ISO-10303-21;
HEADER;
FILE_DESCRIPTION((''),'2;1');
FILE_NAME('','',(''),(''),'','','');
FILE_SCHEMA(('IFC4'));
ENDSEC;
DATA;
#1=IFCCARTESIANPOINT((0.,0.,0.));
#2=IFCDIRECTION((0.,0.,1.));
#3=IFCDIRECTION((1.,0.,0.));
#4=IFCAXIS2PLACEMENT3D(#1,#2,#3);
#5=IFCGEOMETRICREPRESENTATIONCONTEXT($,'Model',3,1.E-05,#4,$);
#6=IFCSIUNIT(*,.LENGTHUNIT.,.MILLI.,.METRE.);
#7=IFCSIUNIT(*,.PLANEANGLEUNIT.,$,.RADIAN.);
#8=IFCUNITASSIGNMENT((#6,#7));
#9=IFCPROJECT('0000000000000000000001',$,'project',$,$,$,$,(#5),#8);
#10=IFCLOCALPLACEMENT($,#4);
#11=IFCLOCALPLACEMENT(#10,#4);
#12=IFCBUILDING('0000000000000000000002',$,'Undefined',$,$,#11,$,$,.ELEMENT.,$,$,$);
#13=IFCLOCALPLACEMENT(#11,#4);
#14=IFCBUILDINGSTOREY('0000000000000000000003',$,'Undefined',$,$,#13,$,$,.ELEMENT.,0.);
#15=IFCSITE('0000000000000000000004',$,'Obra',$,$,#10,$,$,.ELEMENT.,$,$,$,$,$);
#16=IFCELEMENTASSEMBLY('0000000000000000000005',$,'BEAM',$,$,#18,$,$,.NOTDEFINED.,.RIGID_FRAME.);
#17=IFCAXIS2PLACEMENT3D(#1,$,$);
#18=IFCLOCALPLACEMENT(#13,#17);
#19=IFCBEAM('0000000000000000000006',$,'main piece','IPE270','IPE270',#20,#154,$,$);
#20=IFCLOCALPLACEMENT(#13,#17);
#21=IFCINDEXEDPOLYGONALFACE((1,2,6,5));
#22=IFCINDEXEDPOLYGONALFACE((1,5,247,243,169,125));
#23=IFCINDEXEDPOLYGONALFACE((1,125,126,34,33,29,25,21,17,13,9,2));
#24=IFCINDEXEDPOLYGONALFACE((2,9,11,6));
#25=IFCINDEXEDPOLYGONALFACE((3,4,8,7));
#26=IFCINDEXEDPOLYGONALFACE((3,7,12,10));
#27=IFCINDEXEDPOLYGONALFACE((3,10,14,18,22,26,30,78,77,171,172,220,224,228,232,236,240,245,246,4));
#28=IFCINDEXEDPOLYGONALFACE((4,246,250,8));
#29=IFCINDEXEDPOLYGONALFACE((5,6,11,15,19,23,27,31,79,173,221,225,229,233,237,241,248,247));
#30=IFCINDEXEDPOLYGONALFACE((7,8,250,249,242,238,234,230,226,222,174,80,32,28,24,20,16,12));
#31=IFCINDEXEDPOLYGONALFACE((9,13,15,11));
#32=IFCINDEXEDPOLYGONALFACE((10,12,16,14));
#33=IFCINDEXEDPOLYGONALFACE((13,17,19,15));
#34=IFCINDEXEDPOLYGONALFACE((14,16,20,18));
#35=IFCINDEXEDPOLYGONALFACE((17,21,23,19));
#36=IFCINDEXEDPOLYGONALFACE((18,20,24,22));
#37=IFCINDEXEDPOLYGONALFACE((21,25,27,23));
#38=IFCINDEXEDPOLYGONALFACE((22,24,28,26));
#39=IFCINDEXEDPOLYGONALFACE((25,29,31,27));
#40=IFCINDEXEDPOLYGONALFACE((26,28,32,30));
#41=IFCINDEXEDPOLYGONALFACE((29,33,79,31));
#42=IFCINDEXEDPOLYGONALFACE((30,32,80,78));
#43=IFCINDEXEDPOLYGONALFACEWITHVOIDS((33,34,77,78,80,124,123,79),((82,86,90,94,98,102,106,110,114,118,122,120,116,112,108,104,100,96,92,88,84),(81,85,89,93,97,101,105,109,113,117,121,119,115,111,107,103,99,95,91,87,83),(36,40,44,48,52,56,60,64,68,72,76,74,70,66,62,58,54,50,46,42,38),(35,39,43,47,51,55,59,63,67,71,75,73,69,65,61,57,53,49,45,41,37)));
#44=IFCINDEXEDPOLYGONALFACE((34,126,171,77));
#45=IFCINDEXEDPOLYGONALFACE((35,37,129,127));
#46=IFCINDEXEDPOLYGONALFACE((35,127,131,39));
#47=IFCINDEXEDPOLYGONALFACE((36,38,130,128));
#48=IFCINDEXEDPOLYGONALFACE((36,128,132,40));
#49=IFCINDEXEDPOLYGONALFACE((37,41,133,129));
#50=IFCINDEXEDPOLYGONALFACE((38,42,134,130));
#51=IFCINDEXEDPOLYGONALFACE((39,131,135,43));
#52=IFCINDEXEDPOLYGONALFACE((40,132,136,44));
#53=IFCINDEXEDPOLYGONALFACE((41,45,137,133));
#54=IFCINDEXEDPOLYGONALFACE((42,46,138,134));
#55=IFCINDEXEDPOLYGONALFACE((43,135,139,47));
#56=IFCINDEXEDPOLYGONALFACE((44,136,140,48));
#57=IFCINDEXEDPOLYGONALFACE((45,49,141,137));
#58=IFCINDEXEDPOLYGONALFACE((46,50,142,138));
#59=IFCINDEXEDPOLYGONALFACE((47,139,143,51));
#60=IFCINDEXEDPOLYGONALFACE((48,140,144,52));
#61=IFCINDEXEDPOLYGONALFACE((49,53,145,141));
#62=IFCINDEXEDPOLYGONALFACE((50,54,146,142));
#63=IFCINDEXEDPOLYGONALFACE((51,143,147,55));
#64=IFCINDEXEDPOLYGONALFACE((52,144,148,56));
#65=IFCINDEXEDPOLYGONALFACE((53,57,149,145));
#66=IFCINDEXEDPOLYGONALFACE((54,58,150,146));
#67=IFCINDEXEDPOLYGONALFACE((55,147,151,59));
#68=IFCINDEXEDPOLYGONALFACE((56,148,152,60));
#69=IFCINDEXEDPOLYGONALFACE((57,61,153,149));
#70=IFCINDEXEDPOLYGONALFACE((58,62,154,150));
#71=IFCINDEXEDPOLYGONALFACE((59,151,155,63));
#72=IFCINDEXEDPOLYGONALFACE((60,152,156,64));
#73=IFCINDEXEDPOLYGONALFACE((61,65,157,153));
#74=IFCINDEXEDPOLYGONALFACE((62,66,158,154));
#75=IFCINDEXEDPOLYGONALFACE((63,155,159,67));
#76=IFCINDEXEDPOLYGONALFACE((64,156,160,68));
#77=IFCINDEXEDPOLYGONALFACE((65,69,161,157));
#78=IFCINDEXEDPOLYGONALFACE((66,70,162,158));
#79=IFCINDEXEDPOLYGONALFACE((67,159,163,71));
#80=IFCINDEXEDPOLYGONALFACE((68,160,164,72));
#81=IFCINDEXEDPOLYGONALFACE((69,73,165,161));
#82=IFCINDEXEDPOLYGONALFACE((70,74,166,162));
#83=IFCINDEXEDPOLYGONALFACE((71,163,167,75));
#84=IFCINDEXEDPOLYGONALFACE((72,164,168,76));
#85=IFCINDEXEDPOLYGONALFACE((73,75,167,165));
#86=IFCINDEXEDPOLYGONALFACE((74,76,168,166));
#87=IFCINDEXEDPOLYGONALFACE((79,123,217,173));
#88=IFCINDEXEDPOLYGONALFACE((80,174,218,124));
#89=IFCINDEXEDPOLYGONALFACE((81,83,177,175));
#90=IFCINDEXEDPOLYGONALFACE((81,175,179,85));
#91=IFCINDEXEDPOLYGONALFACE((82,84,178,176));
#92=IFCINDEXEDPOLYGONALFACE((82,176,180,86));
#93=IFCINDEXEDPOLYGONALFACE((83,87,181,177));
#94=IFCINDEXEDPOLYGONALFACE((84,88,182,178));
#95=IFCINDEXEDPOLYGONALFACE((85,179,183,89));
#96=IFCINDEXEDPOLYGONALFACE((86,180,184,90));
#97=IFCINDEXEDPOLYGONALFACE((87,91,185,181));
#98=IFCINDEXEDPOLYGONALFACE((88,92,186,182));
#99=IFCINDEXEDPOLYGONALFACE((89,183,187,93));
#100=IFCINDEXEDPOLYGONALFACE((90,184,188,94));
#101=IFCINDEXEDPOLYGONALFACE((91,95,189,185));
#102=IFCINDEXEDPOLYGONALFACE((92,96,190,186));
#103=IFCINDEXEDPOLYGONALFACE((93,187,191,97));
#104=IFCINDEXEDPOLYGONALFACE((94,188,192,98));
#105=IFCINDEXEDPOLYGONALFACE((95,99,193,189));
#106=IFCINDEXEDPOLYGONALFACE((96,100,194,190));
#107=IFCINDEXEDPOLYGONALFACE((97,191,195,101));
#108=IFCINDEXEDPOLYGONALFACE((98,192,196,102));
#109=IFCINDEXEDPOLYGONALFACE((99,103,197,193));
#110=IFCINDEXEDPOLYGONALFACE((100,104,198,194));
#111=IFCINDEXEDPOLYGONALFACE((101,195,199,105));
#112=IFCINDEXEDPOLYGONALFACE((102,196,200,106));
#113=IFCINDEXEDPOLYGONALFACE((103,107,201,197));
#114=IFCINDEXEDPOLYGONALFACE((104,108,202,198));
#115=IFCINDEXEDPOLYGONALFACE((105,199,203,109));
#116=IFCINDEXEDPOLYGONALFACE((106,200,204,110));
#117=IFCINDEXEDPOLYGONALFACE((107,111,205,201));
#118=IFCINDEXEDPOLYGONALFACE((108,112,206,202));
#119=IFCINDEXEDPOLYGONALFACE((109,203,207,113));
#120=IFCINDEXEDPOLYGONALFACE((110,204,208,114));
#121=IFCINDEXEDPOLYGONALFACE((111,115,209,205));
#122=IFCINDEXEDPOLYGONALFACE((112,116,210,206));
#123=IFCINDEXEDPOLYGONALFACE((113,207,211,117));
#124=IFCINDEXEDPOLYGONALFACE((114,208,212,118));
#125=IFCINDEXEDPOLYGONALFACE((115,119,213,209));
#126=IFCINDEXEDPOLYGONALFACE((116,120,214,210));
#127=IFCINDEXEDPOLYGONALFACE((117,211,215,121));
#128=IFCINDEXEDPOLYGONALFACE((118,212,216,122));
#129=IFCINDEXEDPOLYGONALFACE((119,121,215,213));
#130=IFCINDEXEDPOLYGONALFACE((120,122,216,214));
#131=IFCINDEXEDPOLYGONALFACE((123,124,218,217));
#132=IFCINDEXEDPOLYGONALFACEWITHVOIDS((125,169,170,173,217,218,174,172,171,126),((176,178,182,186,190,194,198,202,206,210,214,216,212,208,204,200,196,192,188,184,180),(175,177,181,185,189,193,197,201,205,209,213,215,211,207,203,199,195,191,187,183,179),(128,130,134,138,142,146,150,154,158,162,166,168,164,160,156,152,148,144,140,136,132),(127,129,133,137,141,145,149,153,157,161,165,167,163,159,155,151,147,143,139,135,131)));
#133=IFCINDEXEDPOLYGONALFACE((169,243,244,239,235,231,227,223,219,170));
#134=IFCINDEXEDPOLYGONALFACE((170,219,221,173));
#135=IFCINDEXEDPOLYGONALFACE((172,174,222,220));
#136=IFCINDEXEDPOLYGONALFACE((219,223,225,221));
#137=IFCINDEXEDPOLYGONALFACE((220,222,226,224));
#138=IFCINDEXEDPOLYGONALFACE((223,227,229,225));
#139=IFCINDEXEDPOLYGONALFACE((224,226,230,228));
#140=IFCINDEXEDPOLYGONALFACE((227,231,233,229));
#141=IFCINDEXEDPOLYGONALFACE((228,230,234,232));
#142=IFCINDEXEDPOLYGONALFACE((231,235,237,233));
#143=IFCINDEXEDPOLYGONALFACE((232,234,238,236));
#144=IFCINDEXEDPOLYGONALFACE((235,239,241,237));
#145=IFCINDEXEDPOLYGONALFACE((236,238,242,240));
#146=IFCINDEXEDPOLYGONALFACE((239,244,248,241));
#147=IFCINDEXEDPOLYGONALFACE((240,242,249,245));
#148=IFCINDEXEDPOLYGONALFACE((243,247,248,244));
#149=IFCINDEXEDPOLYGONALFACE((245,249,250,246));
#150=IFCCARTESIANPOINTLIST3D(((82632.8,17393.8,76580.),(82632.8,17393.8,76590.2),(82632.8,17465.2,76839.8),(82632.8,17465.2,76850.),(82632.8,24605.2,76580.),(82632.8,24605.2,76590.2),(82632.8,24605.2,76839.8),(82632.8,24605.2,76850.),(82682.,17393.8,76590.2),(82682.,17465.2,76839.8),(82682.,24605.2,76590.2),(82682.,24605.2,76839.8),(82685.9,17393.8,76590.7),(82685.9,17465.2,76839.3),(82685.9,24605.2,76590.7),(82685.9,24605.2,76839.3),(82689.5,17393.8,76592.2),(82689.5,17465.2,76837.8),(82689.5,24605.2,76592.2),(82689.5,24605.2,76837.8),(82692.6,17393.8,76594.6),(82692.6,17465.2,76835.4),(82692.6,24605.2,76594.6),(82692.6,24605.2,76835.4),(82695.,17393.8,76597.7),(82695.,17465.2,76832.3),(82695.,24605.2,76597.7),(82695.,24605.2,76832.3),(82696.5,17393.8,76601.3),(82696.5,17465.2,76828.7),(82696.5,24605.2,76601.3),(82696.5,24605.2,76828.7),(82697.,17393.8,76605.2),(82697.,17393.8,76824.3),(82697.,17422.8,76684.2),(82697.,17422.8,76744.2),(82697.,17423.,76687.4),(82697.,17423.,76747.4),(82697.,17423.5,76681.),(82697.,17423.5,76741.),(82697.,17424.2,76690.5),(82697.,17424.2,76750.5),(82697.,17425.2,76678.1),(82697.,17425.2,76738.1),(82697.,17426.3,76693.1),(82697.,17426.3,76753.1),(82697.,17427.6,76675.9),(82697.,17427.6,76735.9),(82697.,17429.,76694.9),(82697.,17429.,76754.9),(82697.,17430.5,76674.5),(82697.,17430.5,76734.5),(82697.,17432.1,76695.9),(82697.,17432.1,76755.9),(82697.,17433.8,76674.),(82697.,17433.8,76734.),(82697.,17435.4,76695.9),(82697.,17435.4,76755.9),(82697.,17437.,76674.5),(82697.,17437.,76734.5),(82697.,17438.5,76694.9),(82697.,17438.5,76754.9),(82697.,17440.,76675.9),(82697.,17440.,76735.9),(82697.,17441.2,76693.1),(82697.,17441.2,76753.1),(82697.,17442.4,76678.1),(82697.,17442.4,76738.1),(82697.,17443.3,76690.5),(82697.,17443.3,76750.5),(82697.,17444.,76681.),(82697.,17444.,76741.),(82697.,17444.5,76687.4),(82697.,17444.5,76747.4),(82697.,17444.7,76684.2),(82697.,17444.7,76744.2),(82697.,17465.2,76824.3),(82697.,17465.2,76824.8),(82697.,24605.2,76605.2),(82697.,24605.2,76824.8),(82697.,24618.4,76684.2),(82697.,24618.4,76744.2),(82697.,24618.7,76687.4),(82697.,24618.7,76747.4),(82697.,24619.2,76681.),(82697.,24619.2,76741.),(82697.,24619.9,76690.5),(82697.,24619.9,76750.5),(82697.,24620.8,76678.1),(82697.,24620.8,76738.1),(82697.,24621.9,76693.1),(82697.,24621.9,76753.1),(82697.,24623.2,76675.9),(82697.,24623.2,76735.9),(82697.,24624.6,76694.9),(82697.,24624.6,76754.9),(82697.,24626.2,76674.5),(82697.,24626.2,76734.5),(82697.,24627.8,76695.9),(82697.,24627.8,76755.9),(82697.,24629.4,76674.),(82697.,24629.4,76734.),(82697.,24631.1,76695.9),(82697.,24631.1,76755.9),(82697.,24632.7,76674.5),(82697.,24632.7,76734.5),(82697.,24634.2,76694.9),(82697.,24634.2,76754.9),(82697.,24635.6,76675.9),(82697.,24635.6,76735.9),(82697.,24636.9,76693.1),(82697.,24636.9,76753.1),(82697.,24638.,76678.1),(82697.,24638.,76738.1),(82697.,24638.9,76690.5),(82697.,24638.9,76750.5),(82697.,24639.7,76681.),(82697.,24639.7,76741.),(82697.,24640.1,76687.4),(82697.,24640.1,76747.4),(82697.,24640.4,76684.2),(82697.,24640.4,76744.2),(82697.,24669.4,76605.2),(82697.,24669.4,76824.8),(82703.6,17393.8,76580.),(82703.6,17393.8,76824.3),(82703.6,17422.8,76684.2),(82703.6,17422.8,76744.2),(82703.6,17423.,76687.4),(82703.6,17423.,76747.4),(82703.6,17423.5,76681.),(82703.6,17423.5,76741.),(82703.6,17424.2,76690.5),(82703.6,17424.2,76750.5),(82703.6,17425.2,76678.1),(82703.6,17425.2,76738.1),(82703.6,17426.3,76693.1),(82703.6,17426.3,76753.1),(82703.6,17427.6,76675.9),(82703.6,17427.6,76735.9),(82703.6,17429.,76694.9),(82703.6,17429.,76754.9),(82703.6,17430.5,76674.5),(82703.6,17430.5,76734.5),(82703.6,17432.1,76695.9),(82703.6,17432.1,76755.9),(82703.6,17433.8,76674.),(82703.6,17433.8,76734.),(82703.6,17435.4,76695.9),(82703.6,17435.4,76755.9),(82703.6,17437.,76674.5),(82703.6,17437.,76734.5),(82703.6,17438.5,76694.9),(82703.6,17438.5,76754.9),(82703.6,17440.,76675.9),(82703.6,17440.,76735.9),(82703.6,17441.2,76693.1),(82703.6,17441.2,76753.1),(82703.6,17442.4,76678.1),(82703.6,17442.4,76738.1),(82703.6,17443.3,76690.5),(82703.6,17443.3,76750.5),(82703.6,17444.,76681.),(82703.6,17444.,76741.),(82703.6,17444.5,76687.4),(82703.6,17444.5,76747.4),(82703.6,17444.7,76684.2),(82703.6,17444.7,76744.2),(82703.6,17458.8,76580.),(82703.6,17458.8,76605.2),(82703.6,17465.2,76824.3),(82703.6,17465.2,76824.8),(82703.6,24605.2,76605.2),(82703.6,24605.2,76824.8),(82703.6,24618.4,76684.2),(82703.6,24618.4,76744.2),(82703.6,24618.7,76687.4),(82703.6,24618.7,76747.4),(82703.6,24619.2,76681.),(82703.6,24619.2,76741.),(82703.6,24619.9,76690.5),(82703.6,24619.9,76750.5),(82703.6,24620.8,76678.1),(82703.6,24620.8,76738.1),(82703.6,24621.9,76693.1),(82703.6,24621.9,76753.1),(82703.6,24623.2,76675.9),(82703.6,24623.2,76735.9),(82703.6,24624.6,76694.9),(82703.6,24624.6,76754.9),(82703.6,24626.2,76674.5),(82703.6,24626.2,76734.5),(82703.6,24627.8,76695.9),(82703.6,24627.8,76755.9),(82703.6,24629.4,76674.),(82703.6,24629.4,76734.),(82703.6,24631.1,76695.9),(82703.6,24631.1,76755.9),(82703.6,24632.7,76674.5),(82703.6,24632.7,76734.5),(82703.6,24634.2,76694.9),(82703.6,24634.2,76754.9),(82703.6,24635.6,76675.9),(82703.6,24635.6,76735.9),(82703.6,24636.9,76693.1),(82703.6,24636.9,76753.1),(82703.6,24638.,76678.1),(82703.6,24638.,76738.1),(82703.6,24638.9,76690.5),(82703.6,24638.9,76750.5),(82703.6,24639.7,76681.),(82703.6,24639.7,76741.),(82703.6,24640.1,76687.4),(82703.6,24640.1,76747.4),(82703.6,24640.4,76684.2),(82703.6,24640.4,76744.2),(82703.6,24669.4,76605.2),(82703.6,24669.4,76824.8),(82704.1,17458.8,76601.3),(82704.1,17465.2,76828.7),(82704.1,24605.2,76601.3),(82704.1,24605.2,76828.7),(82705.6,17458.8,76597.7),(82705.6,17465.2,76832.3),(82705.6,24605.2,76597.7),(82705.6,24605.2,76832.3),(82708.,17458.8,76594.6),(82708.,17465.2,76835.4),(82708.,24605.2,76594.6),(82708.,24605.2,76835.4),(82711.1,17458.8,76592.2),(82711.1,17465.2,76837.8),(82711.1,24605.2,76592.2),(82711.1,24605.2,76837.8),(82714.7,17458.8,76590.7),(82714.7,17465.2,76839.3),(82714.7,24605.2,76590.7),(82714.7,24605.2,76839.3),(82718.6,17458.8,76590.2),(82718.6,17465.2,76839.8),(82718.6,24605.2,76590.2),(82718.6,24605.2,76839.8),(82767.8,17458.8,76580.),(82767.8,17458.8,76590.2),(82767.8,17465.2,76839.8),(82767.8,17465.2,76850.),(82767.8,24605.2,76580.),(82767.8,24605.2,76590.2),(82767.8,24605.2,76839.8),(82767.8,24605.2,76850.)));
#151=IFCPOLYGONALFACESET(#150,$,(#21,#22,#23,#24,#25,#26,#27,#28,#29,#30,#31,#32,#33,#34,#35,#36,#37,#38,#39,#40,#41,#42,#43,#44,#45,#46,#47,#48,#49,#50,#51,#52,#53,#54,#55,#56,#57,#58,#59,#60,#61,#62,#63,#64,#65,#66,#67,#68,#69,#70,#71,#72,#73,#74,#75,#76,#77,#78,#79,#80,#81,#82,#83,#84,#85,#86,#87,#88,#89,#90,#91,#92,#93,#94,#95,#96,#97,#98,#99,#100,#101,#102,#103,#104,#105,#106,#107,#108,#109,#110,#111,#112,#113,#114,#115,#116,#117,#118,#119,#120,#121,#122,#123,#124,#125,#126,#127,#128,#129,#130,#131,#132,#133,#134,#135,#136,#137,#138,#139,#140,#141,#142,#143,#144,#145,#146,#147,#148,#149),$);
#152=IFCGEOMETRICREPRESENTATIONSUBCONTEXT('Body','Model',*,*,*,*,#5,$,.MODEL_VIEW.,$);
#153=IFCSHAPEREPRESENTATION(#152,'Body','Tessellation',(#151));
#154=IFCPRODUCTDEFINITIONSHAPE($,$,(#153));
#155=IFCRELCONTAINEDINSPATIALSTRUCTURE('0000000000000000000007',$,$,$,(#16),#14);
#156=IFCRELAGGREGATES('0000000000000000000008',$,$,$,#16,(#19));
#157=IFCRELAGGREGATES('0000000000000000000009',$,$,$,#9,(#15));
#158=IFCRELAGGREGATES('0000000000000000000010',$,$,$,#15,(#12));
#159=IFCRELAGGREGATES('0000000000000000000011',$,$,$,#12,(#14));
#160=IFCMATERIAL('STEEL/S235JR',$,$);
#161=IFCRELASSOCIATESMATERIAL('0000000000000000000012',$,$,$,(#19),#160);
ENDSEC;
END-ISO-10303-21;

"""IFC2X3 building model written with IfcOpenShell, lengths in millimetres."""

from ifc_helpers import new_model, si_unit, frame, origin_with_axes, origin_2d_with_axis, place, context, subcontext, project, spatial, rectangle, circle, i_section, extrude, clip, halfspace, source, transform, mapped, material, element, aggregate, save


model = new_model("IFC2X3")

# Units and contexts
model_context = context("Model", 3, precision=1e-05, world=origin_with_axes())
body_context = subcontext(model_context, "Body", "Model", "MODEL_VIEW")
ifc_project = project(units=[si_unit("LENGTHUNIT", "METRE", prefix="MILLI"), si_unit("PLANEANGLEUNIT", "RADIAN")], contexts=[model_context])

# Site, building, storey
site_placement = place(None, origin_with_axes())
site = spatial("IfcSite", under=ifc_project, at=site_placement, Name="Obra", CompositionType="ELEMENT")
building_placement = place(site_placement, origin_with_axes())
building = spatial("IfcBuilding", under=site, at=building_placement, Name="Undefined", CompositionType="ELEMENT")
storey_placement = place(building_placement, origin_with_axes())
storey = spatial("IfcBuildingStorey", under=building, at=storey_placement, Name="Undefined", CompositionType="ELEMENT", Elevation=0.0)

# Shared definitions
ifc_material = material(Name="STEEL/S235JR")

# Element assembly, beam, openings
assembly_1_placement = place(storey_placement, origin_with_axes())
assembly_1 = element("IfcElementAssembly", 1, at=assembly_1_placement, inside=storey, Name="BEAM", AssemblyPlace="NOTDEFINED", PredefinedType="RIGID_FRAME")
beam_1_placement = place(assembly_1_placement, frame((82700.3, 17482.5, 76715.0), z_axis=(0.0, 0.0, 1.0), x_axis=(0.0, 1.0, 0.0)))
beam_1 = element("IfcBeam", 2, at=beam_1_placement, material=ifc_material, Name="main piece", Description="IPE270", ObjectType="IPE270", context=body_context, shape_type="Clipping", body=[
    clip(clip(extrude(i_section(OverallWidth=135.0, OverallDepth=270.0, WebThickness=6.6, FlangeThickness=10.2, FilletRadius=15.0, at=origin_2d_with_axis()), frame((7186.9, 0.0, 0.0), z_axis=(-1.0, 0.0, 0.0), x_axis=(0.0, -1.0, 0.0)), (0.0, 0.0, 1.0), 7275.7), halfspace(frame((7186.9, 0.0, -235.0), z_axis=(-1.0, -0.000002, 0.0), x_axis=(-0.000002, 1.0, 0.0)), True)), halfspace(frame((-88.7, 0.0, -235.0), z_axis=(1.0, 0.0, 0.0), x_axis=(0.0, -1.0, 0.0)), True)),
])
opening_1_placement = place(assembly_1_placement, frame((82700.3, 17482.5, 76715.0), z_axis=(0.0, 0.0, 1.0), x_axis=(0.0, 1.0, 0.0)))
element("IfcOpeningElement", 3, at=opening_1_placement, cuts=beam_1, ObjectType="Recess", context=body_context, shape_type="SweptSolid", body=[
    extrude(rectangle(XDim=75.0, YDim=300.0, at=origin_2d_with_axis()), frame((-61.2, -153.3, 124.3), z_axis=(0.0, 0.0, -1.0), x_axis=(1.0, 0.0, 0.0)), (0.0, 0.0, 1.0), 278.6),
])
opening_2_placement = place(assembly_1_placement, frame((82700.3, 17482.5, 76715.0), z_axis=(0.0, 0.0, 1.0), x_axis=(0.0, 1.0, 0.0)))
element("IfcOpeningElement", 4, at=opening_2_placement, cuts=beam_1, ObjectType="Recess", context=body_context, shape_type="SweptSolid", body=[
    extrude(rectangle(XDim=26.7, YDim=83.5, at=origin_2d_with_axis()), frame((-59.0, -68.5, 122.7), z_axis=(0.0, 1.0, 0.0), x_axis=(0.0, 0.0, -1.0)), (0.0, 0.0, 1.0), 137.0),
])
opening_3_placement = place(assembly_1_placement, frame((82700.3, 17482.5, 76715.0), z_axis=(0.0, 0.0, 1.0), x_axis=(0.0, 1.0, 0.0)))
element("IfcOpeningElement", 5, at=opening_3_placement, cuts=beam_1, ObjectType="Recess", context=body_context, shape_type="SweptSolid", body=[
    extrude(rectangle(XDim=26.2, YDim=76.2, at=origin_2d_with_axis()), frame((7160.8, 68.5, -122.9), z_axis=(0.000002, -1.0, 0.0), x_axis=(0.0, 0.0, -1.0)), (0.0, 0.0, 1.0), 137.0),
])
opening_4_placement = place(assembly_1_placement, frame((82700.3, 17482.5, 76715.0), z_axis=(0.0, 0.0, 1.0), x_axis=(0.0, 1.0, 0.0)))
element("IfcOpeningElement", 6, at=opening_4_placement, cuts=beam_1, ObjectType="Recess", context=body_context, shape_type="SweptSolid", body=[
    extrude(rectangle(XDim=26.2, YDim=76.2, at=origin_2d_with_axis()), frame((7160.8, 68.5, 122.9), z_axis=(0.000002, -1.0, 0.0), x_axis=(0.0, 0.0, -1.0)), (0.0, 0.0, 1.0), 137.0),
])
shared_shape = source(origin_with_axes(), body_context, "Body", "SweptSolid", [
    extrude(circle(Radius=11.0, at=origin_2d_with_axis()), frame((0.0, -3.4, 0.0), z_axis=(0.0, 1.0, 0.0), x_axis=(1.0, 0.0, 0.0)), (0.0, 0.0, 1.0), 6.8),
])
opening_5_placement = place(assembly_1_placement, frame((82700.3, 17393.8, 76850.0), z_axis=(0.0, 1.0, 0.0), x_axis=(0.0, 0.0, -1.0)))
element("IfcOpeningElement", 7, at=opening_5_placement, cuts=beam_1, ObjectType="Opening", context=body_context, shape_type="MappedRepresentation", body=[
    mapped(shared_shape, transform((105.0, 0.0, 40.0))),
    mapped(shared_shape, transform((165.0, 0.0, 40.0))),
])
opening_6_placement = place(assembly_1_placement, frame((82700.3, 24669.4, 76850.0), z_axis=(0.000002, -1.0, 0.0), x_axis=(0.0, 0.0, -1.0)))
element("IfcOpeningElement", 8, at=opening_6_placement, cuts=beam_1, ObjectType="Opening", context=body_context, shape_type="MappedRepresentation", body=[
    mapped(shared_shape, transform((105.0, 0.0, 40.0))),
    mapped(shared_shape, transform((165.0, 0.0, 40.0))),
])
aggregate(assembly_1, [beam_1])

save(model, "model.ifc")
